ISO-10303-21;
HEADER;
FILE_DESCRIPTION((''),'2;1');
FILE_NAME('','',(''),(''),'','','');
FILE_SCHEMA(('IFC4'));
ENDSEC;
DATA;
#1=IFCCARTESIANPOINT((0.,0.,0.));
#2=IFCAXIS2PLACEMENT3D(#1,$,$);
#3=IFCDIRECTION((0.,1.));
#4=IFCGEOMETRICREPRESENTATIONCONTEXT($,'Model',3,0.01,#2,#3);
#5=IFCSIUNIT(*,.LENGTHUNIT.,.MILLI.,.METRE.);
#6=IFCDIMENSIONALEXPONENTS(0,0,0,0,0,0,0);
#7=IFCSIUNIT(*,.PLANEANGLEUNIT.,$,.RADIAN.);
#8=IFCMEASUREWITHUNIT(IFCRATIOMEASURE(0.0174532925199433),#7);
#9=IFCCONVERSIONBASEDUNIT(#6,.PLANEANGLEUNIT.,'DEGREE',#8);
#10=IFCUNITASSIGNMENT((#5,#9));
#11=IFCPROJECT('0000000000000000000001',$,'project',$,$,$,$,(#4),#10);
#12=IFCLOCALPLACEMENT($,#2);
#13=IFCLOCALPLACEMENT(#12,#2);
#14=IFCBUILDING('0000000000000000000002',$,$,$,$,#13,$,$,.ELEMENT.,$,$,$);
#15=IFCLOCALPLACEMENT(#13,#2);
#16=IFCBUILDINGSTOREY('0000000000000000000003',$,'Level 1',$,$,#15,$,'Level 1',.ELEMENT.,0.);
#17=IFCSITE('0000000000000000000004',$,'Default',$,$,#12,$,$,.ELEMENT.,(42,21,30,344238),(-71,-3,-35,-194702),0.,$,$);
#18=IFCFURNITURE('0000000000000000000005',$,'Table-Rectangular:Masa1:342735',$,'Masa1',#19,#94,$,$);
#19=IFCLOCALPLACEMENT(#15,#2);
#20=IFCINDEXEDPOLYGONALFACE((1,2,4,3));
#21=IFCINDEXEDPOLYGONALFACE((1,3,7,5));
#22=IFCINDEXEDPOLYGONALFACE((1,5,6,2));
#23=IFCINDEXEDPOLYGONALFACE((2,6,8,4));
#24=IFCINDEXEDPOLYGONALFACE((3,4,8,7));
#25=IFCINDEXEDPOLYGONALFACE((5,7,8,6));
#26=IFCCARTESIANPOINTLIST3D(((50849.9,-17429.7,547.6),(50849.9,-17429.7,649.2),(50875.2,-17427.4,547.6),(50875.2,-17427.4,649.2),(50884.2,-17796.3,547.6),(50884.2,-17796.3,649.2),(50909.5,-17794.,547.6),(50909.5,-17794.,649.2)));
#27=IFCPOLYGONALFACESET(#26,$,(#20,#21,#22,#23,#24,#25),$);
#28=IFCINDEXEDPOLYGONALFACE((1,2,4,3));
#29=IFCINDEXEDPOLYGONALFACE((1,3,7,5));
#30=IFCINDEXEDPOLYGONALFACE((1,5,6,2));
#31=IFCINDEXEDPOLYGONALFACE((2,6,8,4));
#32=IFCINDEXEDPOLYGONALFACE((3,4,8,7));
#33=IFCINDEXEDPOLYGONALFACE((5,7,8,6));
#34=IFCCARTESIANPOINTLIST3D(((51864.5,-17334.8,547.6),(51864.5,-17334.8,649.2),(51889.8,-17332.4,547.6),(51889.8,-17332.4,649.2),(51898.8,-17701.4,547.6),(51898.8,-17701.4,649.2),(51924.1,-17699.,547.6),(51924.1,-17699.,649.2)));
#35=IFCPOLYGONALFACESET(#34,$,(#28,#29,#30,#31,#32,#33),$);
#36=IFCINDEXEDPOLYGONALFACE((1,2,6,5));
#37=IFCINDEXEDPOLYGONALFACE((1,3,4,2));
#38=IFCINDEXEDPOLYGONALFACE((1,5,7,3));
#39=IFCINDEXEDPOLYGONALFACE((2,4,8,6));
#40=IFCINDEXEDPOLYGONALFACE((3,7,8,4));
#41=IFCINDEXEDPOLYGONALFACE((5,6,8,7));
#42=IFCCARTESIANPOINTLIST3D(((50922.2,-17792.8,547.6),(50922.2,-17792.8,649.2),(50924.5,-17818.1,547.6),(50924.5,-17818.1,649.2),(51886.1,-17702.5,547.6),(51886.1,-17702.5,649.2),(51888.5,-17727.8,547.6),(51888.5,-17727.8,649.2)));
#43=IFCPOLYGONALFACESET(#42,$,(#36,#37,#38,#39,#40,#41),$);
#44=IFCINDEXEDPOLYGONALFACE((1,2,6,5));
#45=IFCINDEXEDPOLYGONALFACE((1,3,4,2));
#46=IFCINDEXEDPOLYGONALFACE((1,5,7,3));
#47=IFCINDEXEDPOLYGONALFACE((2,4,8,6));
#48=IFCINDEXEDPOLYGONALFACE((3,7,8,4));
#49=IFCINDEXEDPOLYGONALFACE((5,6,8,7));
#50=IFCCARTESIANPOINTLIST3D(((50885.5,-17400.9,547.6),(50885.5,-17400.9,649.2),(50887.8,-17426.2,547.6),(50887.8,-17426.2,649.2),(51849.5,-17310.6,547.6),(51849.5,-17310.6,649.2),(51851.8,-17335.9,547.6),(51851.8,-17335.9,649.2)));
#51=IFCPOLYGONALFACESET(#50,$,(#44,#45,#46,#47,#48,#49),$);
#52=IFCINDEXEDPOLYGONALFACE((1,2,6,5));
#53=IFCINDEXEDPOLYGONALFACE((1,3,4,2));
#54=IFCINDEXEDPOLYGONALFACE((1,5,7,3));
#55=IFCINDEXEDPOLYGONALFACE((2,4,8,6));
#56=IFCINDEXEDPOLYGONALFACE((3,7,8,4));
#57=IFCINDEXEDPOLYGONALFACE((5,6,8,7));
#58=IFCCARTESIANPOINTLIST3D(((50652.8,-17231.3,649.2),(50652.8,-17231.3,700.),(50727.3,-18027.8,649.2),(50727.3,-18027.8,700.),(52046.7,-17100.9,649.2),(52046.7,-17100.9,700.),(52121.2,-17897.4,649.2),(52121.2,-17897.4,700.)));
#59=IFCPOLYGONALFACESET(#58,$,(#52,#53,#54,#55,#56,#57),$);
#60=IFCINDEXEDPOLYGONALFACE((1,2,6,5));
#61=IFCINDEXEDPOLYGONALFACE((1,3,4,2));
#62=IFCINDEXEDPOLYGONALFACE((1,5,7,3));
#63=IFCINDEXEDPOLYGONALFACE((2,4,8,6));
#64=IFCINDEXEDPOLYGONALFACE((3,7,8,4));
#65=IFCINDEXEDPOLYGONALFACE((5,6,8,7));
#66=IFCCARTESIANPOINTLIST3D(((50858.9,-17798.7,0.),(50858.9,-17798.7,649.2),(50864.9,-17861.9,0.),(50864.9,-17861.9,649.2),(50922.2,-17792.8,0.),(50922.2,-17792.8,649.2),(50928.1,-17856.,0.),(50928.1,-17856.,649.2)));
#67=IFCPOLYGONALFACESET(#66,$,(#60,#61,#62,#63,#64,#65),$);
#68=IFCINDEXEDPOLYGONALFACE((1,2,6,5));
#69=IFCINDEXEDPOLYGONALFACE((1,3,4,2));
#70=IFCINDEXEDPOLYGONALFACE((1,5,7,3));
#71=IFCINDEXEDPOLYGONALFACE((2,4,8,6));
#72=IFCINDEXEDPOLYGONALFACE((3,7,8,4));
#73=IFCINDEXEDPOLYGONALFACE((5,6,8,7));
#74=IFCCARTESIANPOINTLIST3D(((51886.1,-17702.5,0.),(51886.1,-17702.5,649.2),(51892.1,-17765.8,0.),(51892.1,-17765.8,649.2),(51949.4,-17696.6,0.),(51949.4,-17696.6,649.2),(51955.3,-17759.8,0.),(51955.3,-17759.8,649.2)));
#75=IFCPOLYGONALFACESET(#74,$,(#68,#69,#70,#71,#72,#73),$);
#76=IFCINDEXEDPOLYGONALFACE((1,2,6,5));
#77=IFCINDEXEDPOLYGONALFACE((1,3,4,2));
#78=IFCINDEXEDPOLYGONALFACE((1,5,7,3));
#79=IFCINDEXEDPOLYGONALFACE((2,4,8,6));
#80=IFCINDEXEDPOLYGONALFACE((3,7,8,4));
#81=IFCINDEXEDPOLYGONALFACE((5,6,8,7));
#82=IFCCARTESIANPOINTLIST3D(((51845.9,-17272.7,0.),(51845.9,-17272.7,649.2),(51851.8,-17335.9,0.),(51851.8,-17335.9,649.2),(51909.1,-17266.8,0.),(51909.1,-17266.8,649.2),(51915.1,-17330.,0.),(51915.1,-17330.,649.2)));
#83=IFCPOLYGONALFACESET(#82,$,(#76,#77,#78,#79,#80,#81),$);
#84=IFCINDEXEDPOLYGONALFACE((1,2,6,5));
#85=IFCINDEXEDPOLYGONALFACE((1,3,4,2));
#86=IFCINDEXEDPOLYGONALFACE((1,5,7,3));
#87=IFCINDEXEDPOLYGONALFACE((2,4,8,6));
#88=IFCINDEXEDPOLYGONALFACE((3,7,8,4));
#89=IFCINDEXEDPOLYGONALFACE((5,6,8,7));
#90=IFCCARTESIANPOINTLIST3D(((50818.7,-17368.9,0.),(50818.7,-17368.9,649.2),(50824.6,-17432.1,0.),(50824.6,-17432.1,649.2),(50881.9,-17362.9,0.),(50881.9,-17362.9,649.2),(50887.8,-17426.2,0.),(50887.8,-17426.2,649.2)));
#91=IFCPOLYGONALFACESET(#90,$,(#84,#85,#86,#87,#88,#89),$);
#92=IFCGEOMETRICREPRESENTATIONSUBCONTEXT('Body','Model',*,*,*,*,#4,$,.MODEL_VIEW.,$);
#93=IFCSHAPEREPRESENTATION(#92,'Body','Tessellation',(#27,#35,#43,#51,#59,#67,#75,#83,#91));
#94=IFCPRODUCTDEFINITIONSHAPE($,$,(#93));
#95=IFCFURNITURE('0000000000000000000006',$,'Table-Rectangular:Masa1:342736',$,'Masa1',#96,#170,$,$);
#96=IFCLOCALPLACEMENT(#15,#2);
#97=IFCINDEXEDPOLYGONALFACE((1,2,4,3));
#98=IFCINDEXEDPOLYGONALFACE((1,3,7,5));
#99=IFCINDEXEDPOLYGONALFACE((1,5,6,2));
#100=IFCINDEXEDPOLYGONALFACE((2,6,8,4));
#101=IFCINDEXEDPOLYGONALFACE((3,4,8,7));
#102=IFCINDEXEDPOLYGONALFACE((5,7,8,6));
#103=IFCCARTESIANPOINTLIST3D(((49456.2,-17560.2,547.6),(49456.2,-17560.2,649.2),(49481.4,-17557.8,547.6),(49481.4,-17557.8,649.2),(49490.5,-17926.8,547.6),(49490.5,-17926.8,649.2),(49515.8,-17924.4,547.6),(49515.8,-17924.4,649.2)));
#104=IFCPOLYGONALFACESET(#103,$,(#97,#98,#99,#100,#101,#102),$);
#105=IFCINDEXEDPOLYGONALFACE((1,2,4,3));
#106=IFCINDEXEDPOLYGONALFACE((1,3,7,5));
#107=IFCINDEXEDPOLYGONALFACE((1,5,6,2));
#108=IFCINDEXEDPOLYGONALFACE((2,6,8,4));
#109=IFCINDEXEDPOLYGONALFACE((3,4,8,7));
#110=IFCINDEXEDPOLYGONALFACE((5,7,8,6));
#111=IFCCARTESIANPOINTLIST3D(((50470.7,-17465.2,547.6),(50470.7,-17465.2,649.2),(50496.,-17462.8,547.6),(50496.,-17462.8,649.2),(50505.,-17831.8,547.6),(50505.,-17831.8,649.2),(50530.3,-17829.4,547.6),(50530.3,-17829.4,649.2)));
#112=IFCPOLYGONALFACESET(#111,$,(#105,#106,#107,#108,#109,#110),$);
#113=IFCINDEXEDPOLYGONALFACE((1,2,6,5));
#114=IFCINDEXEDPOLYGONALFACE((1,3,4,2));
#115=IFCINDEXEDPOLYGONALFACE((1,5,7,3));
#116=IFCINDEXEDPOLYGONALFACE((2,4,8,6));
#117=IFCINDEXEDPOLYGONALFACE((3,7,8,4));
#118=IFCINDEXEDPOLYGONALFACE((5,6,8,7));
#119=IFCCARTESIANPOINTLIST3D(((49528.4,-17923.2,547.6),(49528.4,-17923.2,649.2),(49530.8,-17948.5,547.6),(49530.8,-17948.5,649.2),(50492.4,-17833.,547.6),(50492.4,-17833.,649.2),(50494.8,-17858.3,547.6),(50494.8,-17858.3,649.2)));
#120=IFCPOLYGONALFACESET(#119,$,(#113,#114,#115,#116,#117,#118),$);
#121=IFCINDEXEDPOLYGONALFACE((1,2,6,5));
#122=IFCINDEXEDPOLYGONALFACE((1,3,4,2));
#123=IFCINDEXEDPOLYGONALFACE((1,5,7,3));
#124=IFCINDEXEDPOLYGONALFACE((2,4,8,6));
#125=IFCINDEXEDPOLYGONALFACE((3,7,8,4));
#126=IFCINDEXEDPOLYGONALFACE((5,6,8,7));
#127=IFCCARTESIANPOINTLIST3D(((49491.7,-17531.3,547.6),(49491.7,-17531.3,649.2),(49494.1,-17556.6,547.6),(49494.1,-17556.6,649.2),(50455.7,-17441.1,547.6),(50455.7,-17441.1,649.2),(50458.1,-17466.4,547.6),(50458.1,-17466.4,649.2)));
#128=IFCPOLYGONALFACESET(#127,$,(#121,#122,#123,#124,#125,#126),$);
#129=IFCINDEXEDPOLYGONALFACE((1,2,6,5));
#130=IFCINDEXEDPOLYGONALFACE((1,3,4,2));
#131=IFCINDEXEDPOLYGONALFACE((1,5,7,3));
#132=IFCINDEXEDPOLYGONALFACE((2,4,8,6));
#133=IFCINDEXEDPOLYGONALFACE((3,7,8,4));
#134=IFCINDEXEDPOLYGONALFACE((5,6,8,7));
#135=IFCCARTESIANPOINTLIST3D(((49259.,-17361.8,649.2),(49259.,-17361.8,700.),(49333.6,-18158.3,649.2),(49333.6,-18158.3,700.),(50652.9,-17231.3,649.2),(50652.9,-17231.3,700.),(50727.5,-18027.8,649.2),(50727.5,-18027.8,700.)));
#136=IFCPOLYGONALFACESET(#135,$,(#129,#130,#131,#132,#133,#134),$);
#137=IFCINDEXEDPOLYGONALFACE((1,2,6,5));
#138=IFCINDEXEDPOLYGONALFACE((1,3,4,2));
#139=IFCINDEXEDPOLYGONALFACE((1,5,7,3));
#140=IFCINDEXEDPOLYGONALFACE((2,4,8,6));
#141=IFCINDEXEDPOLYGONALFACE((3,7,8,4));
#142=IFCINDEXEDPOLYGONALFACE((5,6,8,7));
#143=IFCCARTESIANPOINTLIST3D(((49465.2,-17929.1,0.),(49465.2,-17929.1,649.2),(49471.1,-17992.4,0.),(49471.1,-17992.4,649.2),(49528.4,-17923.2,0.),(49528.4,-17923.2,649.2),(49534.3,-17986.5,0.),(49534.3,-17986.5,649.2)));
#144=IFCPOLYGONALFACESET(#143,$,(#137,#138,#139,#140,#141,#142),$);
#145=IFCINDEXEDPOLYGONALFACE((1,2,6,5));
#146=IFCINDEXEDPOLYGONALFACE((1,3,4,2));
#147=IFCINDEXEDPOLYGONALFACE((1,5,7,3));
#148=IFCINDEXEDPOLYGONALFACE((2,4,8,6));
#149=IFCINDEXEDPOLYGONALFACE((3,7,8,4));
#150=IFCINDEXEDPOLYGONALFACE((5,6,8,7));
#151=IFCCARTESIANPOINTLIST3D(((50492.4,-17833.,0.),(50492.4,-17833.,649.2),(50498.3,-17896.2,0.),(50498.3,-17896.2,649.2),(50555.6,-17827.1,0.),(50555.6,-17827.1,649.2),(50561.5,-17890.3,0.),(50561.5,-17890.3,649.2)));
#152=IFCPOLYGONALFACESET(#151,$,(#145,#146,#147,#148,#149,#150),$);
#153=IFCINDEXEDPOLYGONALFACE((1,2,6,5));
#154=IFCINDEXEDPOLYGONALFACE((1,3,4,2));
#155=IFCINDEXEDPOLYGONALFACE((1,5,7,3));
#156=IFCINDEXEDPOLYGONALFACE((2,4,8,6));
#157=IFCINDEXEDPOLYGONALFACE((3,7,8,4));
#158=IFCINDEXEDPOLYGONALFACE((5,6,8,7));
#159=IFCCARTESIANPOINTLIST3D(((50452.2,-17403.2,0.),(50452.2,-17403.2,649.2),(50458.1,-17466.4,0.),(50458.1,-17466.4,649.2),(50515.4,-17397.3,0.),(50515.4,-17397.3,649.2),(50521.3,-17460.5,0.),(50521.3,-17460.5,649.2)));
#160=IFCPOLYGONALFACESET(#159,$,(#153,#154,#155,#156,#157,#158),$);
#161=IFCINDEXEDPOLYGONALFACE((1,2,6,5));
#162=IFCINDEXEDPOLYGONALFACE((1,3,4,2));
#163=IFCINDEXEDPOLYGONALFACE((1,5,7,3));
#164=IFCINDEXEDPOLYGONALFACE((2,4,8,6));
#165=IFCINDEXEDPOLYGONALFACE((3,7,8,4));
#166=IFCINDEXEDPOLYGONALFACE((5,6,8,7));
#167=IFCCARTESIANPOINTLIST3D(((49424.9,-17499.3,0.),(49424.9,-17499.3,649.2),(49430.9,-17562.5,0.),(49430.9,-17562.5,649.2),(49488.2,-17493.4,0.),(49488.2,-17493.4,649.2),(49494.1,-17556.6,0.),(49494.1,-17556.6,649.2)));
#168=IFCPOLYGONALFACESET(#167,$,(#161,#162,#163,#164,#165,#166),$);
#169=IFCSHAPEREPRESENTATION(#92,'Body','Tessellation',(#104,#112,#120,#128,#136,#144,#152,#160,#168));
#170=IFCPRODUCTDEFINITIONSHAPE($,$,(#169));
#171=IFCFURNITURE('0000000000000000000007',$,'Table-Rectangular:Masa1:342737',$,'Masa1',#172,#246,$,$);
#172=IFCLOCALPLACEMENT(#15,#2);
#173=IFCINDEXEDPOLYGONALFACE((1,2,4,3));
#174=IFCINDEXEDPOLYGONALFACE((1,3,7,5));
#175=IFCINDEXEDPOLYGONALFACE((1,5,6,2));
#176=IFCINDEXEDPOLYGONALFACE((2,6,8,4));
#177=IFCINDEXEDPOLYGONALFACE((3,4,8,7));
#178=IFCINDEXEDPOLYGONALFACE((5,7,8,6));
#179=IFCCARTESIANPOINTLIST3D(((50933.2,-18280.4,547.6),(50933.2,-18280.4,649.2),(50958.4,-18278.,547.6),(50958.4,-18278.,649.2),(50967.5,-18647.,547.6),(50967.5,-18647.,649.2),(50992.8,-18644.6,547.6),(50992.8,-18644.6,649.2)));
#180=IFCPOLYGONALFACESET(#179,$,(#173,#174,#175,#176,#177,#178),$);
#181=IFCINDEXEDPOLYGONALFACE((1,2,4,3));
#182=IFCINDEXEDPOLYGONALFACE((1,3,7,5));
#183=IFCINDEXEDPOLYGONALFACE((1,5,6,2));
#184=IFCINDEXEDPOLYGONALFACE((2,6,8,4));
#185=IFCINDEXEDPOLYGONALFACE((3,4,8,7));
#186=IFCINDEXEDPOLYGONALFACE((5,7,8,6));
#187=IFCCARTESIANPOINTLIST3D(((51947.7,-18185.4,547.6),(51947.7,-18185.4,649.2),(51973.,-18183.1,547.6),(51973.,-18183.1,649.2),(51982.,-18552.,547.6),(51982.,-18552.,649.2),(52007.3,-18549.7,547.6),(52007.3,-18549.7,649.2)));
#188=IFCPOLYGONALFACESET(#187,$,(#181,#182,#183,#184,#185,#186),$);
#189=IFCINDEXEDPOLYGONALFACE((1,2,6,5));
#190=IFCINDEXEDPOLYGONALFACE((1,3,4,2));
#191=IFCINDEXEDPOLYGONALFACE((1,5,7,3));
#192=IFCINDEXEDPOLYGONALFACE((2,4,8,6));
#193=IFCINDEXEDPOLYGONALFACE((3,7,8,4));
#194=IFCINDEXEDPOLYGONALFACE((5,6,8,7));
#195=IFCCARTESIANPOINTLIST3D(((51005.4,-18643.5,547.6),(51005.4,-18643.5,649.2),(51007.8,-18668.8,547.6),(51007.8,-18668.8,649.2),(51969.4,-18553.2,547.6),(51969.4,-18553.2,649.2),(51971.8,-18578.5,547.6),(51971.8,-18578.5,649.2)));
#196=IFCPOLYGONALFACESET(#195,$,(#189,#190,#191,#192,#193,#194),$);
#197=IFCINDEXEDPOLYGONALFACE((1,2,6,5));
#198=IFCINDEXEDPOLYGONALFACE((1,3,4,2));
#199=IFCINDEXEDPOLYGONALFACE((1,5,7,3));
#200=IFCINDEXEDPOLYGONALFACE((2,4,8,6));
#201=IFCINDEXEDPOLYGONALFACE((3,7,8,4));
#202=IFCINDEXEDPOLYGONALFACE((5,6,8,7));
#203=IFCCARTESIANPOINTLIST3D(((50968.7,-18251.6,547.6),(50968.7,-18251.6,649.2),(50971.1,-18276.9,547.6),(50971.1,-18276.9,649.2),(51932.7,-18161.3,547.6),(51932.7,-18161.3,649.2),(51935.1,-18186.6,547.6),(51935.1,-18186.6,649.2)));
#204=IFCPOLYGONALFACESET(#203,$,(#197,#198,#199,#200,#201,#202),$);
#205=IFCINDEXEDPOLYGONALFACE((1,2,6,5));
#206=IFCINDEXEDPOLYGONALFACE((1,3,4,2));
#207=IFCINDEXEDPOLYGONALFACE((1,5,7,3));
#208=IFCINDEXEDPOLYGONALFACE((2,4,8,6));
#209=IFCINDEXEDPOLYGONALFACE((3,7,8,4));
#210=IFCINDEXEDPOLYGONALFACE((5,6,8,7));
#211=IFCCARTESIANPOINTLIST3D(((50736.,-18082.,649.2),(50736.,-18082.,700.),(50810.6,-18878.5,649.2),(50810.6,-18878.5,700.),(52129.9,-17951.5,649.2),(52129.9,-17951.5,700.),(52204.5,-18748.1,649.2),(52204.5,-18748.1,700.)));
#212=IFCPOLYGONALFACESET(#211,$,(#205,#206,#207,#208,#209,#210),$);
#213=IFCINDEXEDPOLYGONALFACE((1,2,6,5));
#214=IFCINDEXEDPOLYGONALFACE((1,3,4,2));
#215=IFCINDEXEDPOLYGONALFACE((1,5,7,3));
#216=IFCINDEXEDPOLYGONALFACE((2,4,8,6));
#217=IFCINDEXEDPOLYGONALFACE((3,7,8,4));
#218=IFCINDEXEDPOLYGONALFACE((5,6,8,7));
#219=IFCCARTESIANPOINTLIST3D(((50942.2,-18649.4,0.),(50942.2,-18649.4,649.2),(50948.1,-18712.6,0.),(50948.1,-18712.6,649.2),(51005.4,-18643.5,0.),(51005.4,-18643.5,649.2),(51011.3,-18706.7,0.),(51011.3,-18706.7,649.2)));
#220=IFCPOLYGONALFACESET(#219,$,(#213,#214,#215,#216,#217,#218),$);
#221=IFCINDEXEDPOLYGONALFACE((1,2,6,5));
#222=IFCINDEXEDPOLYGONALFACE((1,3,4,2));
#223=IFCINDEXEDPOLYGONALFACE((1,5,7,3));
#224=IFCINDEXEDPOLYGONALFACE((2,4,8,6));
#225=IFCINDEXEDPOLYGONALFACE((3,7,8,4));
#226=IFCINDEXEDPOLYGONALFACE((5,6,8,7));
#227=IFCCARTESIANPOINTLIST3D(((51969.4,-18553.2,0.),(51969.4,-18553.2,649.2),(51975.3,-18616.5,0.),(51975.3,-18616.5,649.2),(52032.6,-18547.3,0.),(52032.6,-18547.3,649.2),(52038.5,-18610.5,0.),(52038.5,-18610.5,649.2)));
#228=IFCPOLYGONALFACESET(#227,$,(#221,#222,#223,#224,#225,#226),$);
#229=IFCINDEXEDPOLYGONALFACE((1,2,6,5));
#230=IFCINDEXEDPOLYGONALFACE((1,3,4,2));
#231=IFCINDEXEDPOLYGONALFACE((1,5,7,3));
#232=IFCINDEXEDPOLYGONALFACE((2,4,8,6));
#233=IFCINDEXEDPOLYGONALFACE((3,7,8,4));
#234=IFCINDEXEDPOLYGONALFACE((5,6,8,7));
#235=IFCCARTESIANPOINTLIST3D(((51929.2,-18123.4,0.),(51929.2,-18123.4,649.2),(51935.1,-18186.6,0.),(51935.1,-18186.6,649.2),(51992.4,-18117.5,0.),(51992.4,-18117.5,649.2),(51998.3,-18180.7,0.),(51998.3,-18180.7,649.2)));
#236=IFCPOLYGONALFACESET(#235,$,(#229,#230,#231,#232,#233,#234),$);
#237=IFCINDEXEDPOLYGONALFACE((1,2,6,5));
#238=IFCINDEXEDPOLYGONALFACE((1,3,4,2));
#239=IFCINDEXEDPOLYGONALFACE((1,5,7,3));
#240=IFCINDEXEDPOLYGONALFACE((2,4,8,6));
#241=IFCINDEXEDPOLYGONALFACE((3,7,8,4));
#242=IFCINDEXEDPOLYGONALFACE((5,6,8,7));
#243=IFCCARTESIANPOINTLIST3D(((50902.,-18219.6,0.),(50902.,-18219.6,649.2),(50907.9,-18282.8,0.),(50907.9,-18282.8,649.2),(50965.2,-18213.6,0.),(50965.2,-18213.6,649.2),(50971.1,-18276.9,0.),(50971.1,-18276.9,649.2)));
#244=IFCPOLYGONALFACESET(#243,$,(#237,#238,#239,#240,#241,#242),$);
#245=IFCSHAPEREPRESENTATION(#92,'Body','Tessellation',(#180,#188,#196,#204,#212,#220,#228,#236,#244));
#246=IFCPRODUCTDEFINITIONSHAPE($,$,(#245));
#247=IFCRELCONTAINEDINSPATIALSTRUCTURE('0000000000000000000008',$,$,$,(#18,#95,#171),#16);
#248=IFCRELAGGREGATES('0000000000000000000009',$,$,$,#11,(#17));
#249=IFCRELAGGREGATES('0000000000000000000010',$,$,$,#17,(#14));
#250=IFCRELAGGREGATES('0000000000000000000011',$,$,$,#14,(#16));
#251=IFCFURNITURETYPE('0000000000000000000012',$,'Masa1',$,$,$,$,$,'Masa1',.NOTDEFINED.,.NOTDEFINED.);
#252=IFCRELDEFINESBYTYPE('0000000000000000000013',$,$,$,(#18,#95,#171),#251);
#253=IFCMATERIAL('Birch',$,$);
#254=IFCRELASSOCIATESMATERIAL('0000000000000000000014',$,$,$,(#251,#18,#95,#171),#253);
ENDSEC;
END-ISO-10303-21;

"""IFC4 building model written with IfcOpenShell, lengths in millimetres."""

from ifc_helpers import new_model, entity, si_unit, converted_unit, direction, frame, frame_2d, origin, origin_2d_with_axis, place, context, subcontext, project, spatial, rectangle, extrude, source, transform, mapped, material, type_object, type_shapes, element, save


model = new_model("IFC4")

# Units and contexts
model_context = context("Model", 3, precision=0.01, world=origin(), true_north=direction((0.0, 1.0)))
body_context = subcontext(model_context, "Body", "Model", "MODEL_VIEW")
ifc_project = project(units=[si_unit("LENGTHUNIT", "METRE", prefix="MILLI"), converted_unit("PLANEANGLEUNIT", "DEGREE", entity("IfcRatioMeasure", 0.0174532925199433), si_unit("PLANEANGLEUNIT", "RADIAN"), dimensions=[0, 0, 0, 0, 0, 0, 0])], contexts=[model_context])

# Site, building, storey
site_placement = place(None, origin())
site = spatial("IfcSite", under=ifc_project, at=site_placement, Name="Default", CompositionType="ELEMENT", RefLatitude=(42, 21, 30, 344238), RefLongitude=(-71, -3, -35, -194702), RefElevation=0.0)
building_placement = place(site_placement, origin())
building = spatial("IfcBuilding", under=site, at=building_placement, CompositionType="ELEMENT")
storey_placement = place(building_placement, origin())
storey = spatial("IfcBuildingStorey", under=building, at=storey_placement, Name="Level 1", LongName="Level 1", CompositionType="ELEMENT", Elevation=0.0)

# Furniture
ifc_material_1 = material(Name="Birch")
furniture_type_1 = type_object("IfcFurnitureType", Name="Masa1", ElementType="Masa1", AssemblyPlace="NOTDEFINED", PredefinedType="NOTDEFINED", material=ifc_material_1)
shared_shape_1 = source(origin(), body_context, "Body", "SweptSolid", [
    extrude(rectangle(XDim=25.4, YDim=368.2, at=origin_2d_with_axis()), frame((509.5, 0.0, 547.6)), (0.0, 0.0, 1.0), 101.6),
    extrude(rectangle(XDim=368.2, YDim=25.4, at=origin_2d_with_axis()), frame((-509.5, 0.0, 547.6), z_axis=(0.0, 0.0, 1.0), x_axis=(0.0, 1.0, 0.0)), (0.0, 0.0, 1.0), 101.6),
    extrude(rectangle(XDim=968.2, YDim=25.4, at=frame_2d((0.0, 0.0), x_axis=(1.0, 0.0))), frame((0.0, 196.8, 547.6), z_axis=(0.0, 0.0, 1.0), x_axis=(-1.0, 0.0, 0.0)), (0.0, 0.0, 1.0), 101.6),
    extrude(rectangle(XDim=25.4, YDim=968.2, at=origin_2d_with_axis()), frame((0.0, -196.8, 547.6), z_axis=(0.0, 0.0, 1.0), x_axis=(0.0, 1.0, 0.0)), (0.0, 0.0, 1.0), 101.6),
    extrude(rectangle(XDim=1400.0, YDim=800.0, at=origin_2d_with_axis()), frame((0.0, 0.0, 649.2), z_axis=(0.0, 0.0, 1.0), x_axis=(-1.0, 0.0, 0.0)), (0.0, 0.0, 1.0), 50.8),
    extrude(rectangle(XDim=63.5, YDim=63.5, at=origin_2d_with_axis()), frame((515.9, 215.9, 0.0), z_axis=(0.0, 0.0, 1.0), x_axis=(0.0, -1.0, 0.0)), (0.0, 0.0, 1.0), 649.2),
    extrude(rectangle(XDim=63.5, YDim=63.5, at=origin_2d_with_axis()), frame((-515.9, 215.9, 0.0), z_axis=(0.0, 0.0, 1.0), x_axis=(-1.0, 0.0, 0.0)), (0.0, 0.0, 1.0), 649.2),
    extrude(rectangle(XDim=63.5, YDim=63.5, at=origin_2d_with_axis()), frame((-515.9, -215.9, 0.0), z_axis=(0.0, 0.0, 1.0), x_axis=(0.0, 1.0, 0.0)), (0.0, 0.0, 1.0), 649.2),
    extrude(rectangle(XDim=63.5, YDim=63.5, at=frame_2d((0.0, 0.0), x_axis=(1.0, 0.0))), frame((515.9, -215.9, 0.0)), (0.0, 0.0, 1.0), 649.2),
])
type_shapes(furniture_type_1, [shared_shape_1])
for number, where, z_axis, x_axis, name in (
    (1, (51387.0, -17564.4, 0.0), (0.0, 0.0, 1.0), (-0.995648, -0.093196, 0.0), "Table-Rectangular:Masa1:342735"),
    (2, (49993.2, -17694.8, 0.0), (0.0, 0.0, 1.0), (-0.995648, -0.093196, 0.0), "Table-Rectangular:Masa1:342736"),
    (3, (51470.2, -18415.0, 0.0), (0.0, 0.0, 1.0), (-0.995648, -0.093196, 0.0), "Table-Rectangular:Masa1:342737"),
):
    element("IfcFurniture", number, at=place(storey_placement, frame(where, z_axis=z_axis, x_axis=x_axis)), inside=storey, type_object=furniture_type_1, material=ifc_material_1, Name=name, ObjectType="Masa1", context=body_context, shape_type="MappedRepresentation", body=[
        mapped(shared_shape_1, transform((0.0, 0.0, 0.0), scale=1.0)),
    ])

save(model, "model.ifc")
